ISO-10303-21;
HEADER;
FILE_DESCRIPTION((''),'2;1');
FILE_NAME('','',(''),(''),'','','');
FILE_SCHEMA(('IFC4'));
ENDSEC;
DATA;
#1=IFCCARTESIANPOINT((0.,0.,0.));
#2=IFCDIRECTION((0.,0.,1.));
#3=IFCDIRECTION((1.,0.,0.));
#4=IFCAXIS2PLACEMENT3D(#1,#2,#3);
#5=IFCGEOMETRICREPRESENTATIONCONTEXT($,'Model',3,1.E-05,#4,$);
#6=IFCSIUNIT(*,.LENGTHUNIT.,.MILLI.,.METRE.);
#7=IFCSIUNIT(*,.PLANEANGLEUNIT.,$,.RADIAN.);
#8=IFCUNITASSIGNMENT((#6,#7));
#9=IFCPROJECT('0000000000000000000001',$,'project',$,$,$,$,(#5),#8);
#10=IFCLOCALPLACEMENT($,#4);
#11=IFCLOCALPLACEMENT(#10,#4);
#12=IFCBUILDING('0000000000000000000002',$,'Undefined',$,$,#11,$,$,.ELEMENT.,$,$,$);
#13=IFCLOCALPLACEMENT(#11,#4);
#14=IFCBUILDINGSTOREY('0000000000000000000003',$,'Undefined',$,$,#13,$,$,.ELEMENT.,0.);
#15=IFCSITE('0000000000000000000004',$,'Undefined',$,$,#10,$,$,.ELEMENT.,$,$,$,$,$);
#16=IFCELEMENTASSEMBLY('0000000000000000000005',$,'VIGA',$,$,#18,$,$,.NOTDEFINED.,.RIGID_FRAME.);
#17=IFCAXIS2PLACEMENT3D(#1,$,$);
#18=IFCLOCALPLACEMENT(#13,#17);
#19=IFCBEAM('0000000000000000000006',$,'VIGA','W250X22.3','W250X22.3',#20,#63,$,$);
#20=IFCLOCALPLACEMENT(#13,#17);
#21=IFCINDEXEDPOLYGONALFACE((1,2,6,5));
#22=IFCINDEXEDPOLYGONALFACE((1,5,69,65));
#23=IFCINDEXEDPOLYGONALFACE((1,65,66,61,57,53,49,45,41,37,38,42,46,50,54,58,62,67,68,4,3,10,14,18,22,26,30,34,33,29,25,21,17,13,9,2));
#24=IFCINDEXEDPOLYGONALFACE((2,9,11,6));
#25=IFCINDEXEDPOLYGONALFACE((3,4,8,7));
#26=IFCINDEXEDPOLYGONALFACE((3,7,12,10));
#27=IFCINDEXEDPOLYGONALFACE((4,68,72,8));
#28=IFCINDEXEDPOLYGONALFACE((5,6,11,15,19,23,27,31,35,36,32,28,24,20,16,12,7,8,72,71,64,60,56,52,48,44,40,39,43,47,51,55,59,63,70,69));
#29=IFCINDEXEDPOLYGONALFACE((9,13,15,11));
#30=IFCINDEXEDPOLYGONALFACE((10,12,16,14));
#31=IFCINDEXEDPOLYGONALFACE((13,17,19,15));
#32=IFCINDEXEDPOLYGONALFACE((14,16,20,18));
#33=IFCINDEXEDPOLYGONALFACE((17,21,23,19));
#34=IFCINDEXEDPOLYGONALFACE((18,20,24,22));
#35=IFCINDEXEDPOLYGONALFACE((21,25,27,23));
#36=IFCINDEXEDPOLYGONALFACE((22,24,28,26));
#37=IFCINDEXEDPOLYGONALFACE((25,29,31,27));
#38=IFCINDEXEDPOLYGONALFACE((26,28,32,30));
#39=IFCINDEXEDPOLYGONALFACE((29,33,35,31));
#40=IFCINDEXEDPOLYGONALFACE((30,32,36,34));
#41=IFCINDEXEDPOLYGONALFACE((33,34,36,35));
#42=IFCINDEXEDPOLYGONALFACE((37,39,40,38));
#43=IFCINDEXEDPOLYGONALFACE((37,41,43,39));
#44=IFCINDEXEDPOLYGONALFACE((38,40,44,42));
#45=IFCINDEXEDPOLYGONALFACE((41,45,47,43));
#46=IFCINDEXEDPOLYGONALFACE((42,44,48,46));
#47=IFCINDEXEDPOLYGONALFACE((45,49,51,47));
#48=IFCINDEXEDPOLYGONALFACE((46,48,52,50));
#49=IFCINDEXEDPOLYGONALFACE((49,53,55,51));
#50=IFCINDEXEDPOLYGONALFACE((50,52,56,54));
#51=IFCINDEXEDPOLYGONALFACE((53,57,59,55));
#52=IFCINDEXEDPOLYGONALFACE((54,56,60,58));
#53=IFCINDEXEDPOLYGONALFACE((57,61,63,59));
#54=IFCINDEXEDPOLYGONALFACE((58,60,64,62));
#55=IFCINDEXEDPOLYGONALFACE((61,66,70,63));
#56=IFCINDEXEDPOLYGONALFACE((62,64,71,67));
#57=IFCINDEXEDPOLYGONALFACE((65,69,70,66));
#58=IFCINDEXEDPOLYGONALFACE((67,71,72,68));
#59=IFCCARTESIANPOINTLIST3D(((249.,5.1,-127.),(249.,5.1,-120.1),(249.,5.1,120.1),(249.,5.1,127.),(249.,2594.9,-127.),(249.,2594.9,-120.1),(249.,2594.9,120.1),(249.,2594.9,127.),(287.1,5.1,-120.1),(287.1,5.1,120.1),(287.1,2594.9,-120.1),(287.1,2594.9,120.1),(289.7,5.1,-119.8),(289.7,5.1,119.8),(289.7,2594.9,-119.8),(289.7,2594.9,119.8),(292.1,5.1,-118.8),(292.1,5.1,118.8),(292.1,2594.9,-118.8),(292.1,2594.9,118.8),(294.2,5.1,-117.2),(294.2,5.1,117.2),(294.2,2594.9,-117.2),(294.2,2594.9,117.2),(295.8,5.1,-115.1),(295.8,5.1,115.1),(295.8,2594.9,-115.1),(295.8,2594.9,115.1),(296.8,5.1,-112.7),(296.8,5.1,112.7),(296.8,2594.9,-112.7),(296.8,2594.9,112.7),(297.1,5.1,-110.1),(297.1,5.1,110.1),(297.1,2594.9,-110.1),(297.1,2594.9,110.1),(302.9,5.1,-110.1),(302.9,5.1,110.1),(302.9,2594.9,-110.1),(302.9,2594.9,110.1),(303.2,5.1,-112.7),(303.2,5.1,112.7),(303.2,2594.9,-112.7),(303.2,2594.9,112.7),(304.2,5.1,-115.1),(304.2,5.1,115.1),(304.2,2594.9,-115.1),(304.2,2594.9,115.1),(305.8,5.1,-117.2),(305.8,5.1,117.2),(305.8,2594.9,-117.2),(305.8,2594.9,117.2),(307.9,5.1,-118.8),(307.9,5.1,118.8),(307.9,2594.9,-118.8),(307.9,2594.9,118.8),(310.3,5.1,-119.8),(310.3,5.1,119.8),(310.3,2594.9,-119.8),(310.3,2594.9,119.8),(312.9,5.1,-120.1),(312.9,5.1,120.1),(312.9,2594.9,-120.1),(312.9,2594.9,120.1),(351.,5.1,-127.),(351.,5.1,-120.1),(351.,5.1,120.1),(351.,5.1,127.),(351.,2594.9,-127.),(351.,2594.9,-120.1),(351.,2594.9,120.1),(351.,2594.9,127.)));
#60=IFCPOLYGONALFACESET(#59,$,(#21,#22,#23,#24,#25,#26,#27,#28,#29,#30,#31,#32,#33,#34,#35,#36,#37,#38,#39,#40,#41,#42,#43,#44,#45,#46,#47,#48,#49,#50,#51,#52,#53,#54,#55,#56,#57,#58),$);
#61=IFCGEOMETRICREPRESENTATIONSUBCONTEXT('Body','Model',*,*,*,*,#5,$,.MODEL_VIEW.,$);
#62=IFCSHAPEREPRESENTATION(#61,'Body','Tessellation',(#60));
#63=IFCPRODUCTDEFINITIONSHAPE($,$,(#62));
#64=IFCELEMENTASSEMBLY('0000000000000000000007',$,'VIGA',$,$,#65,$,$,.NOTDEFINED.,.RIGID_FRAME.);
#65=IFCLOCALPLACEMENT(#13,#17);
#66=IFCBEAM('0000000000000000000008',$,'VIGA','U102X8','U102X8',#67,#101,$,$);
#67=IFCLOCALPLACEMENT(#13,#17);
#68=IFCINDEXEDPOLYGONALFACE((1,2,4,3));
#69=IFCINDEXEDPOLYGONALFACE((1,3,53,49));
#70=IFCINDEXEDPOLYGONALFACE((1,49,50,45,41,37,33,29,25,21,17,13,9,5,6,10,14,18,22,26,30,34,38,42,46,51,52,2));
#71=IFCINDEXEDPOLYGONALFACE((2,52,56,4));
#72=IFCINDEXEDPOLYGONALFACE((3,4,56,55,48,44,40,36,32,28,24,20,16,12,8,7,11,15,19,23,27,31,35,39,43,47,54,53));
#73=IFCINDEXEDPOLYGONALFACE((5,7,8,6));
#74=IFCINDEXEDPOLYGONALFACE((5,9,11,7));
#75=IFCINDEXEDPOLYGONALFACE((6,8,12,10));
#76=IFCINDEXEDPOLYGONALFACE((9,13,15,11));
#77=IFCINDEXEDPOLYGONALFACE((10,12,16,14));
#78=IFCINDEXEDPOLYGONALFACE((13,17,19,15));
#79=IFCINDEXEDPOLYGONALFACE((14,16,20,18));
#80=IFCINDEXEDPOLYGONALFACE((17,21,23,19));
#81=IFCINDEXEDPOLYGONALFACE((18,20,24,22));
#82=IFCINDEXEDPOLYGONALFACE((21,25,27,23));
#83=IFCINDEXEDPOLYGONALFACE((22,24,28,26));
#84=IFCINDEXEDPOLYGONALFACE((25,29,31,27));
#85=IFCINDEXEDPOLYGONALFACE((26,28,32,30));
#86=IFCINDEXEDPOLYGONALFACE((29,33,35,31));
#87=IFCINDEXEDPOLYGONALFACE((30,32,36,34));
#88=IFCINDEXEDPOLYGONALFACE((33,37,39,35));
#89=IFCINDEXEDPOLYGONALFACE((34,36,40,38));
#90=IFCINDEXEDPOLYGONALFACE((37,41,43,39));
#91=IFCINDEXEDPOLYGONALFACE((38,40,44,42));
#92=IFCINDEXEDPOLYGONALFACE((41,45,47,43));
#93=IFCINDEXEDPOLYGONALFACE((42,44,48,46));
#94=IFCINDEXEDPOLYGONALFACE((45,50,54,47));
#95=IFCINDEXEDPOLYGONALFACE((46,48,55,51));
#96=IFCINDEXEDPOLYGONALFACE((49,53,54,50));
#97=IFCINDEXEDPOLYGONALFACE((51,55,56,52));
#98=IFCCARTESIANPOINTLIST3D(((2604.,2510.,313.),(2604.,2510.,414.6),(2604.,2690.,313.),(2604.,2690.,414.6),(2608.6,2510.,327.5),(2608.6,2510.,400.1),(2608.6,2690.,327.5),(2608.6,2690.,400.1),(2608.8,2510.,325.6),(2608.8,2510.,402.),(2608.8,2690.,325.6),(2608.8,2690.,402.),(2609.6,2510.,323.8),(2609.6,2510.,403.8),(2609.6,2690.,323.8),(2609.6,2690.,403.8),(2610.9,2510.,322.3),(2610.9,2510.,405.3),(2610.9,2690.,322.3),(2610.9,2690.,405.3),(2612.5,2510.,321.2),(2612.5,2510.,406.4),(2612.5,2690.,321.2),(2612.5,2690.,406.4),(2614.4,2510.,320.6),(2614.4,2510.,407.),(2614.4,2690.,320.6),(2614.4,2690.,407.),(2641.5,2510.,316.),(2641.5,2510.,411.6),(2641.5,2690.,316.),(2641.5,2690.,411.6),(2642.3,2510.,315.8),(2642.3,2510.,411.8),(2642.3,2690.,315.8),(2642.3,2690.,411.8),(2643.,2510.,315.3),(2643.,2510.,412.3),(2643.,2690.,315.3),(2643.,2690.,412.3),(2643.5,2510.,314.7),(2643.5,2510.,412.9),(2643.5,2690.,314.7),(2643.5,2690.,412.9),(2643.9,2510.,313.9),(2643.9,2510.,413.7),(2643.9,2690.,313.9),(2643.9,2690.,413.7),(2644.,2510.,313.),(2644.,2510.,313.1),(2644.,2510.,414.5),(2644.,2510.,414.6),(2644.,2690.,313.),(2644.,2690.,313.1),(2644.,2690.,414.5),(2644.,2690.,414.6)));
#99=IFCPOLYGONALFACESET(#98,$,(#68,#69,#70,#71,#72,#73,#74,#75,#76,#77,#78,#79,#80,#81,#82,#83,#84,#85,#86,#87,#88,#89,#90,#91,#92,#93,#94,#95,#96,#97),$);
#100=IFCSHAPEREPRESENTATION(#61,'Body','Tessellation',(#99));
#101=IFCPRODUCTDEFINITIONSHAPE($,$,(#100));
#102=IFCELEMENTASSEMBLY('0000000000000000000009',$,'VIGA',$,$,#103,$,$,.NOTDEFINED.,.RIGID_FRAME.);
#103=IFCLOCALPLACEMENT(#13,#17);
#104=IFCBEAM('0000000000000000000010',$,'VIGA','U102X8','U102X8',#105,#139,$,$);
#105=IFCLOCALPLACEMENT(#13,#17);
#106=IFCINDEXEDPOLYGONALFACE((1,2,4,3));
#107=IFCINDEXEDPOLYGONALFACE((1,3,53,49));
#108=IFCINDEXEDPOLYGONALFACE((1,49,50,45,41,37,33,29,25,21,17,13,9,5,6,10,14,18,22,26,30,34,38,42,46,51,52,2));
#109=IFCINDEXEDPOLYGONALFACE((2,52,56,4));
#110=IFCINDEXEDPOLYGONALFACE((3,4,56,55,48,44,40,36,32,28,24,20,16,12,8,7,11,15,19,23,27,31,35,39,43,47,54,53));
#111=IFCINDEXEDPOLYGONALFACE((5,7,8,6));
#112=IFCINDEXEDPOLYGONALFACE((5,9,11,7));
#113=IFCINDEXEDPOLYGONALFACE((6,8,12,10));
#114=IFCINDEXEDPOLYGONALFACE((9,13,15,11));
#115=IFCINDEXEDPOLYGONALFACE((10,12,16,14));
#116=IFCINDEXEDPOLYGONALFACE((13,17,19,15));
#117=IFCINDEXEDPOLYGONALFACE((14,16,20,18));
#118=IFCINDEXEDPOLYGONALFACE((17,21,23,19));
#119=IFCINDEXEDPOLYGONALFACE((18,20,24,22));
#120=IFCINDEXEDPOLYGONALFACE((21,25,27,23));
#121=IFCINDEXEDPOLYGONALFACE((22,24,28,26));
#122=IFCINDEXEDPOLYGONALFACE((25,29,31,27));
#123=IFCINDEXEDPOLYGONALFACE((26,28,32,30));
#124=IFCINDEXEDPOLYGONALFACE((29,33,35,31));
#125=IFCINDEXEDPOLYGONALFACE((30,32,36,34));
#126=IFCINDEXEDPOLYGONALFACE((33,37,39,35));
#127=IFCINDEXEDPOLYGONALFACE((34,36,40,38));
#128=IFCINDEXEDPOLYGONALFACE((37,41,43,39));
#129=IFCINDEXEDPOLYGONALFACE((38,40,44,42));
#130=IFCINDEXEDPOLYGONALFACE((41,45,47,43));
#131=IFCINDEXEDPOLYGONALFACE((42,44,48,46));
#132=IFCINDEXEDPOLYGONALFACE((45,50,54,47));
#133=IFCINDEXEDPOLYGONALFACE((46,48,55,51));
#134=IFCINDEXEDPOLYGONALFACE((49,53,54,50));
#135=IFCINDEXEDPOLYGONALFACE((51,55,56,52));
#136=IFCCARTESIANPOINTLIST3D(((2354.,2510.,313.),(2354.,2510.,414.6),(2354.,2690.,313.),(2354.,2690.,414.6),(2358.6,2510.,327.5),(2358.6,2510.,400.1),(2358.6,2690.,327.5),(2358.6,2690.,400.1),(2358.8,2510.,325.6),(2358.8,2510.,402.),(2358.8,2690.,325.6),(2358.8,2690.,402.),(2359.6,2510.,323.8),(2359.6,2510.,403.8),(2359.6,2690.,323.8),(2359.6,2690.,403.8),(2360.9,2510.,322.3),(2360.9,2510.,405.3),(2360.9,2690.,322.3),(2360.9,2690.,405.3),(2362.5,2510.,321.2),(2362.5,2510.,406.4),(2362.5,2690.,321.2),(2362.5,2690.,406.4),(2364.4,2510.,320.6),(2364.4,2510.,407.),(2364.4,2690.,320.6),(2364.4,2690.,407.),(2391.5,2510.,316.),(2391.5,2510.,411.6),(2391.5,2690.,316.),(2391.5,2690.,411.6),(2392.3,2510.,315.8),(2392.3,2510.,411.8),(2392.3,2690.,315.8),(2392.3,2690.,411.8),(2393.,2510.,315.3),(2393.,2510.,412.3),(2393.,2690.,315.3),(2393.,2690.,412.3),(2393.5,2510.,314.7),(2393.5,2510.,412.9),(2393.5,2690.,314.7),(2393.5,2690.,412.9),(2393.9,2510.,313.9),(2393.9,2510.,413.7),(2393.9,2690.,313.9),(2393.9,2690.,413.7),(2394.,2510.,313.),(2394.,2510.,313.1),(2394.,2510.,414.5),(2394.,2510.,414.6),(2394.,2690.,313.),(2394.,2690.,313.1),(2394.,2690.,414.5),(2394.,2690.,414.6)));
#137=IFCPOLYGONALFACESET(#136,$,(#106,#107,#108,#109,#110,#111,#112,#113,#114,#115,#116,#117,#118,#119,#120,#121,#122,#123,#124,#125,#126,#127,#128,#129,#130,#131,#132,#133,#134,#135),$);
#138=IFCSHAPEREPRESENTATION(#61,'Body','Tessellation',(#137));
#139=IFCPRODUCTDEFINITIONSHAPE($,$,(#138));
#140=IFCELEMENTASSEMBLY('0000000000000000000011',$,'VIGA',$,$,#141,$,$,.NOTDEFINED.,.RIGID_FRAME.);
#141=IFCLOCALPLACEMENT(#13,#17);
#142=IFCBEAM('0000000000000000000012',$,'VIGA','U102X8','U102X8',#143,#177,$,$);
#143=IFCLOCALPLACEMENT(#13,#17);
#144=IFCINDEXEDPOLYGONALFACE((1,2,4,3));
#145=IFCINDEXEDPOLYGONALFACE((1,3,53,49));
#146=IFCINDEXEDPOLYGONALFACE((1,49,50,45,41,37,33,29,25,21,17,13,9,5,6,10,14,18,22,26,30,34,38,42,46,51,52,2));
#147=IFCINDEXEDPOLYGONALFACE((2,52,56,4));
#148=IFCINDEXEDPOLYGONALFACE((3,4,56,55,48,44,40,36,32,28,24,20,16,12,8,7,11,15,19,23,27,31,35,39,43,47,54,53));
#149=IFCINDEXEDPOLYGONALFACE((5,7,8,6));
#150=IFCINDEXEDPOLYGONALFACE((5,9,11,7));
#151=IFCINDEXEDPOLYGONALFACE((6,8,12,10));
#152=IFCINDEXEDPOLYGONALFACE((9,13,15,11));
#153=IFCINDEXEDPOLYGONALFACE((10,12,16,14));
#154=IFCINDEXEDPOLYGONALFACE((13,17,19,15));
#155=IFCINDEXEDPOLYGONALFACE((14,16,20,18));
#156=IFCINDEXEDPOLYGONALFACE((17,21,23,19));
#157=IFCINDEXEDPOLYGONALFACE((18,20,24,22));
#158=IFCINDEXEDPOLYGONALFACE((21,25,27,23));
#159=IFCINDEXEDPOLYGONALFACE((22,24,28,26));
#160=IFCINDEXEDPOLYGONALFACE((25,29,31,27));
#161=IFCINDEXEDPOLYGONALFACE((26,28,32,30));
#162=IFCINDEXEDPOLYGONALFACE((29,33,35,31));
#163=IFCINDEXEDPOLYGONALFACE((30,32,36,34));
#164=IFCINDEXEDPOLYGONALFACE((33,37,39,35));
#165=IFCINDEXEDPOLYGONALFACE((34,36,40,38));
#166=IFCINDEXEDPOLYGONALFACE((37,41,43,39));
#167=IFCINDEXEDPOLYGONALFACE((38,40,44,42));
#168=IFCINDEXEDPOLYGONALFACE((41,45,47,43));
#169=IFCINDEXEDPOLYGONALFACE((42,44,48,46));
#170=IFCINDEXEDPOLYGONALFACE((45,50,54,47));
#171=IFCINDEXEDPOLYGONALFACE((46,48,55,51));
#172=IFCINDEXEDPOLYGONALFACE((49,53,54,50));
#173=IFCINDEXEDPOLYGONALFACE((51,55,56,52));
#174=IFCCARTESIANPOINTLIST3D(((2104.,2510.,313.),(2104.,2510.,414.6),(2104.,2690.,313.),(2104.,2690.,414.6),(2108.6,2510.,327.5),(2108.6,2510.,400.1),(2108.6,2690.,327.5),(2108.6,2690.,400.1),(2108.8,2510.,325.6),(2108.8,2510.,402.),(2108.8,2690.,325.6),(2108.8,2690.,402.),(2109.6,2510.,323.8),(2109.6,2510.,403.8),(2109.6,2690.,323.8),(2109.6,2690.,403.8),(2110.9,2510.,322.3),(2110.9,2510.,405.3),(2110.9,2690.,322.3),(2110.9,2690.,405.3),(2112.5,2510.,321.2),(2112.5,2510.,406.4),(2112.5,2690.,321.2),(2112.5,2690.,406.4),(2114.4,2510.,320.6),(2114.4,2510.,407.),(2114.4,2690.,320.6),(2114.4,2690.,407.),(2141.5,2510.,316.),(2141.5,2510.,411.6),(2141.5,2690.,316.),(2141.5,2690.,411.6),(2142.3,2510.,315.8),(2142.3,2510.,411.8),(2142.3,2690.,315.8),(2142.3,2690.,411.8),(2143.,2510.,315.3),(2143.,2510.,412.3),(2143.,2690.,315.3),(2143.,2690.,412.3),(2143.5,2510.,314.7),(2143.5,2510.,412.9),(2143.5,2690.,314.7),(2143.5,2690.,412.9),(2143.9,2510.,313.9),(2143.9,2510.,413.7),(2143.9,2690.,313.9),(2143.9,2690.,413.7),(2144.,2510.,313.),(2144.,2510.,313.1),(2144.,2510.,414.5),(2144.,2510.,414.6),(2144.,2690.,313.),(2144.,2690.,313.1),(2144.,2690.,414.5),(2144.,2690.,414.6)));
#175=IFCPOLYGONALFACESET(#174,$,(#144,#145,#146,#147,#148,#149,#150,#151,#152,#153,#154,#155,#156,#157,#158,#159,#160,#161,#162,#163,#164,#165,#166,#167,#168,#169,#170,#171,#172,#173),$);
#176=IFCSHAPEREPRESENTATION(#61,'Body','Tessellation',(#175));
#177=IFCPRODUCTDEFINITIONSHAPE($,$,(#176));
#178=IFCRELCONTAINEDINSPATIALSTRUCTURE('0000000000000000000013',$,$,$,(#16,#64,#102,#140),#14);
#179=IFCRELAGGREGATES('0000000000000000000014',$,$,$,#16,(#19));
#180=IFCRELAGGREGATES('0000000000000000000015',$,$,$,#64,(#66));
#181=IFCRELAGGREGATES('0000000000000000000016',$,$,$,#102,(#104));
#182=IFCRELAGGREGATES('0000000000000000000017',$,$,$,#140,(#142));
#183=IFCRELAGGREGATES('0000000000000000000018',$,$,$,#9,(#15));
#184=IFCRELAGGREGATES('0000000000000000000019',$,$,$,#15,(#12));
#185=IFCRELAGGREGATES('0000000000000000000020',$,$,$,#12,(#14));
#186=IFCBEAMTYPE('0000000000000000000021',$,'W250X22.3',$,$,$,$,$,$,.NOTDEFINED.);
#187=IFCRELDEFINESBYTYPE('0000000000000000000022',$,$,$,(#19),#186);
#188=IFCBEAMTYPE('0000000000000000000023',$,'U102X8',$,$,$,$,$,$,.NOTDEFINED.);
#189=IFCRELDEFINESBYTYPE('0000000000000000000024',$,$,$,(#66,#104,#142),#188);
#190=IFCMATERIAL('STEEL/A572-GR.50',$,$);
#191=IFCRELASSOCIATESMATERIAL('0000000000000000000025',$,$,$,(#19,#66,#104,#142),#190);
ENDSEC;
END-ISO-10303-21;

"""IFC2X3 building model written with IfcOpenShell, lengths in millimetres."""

from ifc_helpers import new_model, si_unit, frame, origin_with_axes, origin_2d_with_axis, place, context, subcontext, project, spatial, i_section, u_section, extrude, material, type_object, element, aggregate, save


model = new_model("IFC2X3")

# Units and contexts
model_context = context("Model", 3, precision=1e-05, world=origin_with_axes())
body_context = subcontext(model_context, "Body", "Model", "MODEL_VIEW")
ifc_project = project(units=[si_unit("LENGTHUNIT", "METRE", prefix="MILLI"), si_unit("PLANEANGLEUNIT", "RADIAN")], contexts=[model_context])

# Site, building, storey
site_placement = place(None, origin_with_axes())
site = spatial("IfcSite", under=ifc_project, at=site_placement, Name="Undefined", CompositionType="ELEMENT")
building_placement = place(site_placement, origin_with_axes())
building = spatial("IfcBuilding", under=site, at=building_placement, Name="Undefined", CompositionType="ELEMENT")
storey_placement = place(building_placement, origin_with_axes())
storey = spatial("IfcBuildingStorey", under=building, at=storey_placement, Name="Undefined", CompositionType="ELEMENT", Elevation=0.0)

# Element assemblies, beams
assembly_1_placement = place(storey_placement, origin_with_axes())
assembly_1 = element("IfcElementAssembly", 1, at=assembly_1_placement, inside=storey, Name="VIGA", AssemblyPlace="NOTDEFINED", PredefinedType="RIGID_FRAME")
ifc_material_1 = material(Name="STEEL/A572-GR.50")
beam_type_1 = type_object("IfcBeamType", Name="W250X22.3", PredefinedType="NOTDEFINED")
beam_1_placement = place(assembly_1_placement, frame((300.0, 5.1, 0.0), z_axis=(0.0, 0.0, 1.0), x_axis=(0.0, 1.0, 0.0)))
beam_1 = element("IfcBeam", 2, at=beam_1_placement, type_object=beam_type_1, material=ifc_material_1, Name="VIGA", Description="W250X22.3", ObjectType="W250X22.3", context=body_context, shape_type="SweptSolid", body=[
    extrude(i_section(OverallWidth=102.0, OverallDepth=254.0, WebThickness=5.8, FlangeThickness=6.9, FilletRadius=10.0, at=origin_2d_with_axis()), frame((2589.8, 0.0, 0.0), z_axis=(-1.0, 0.0, 0.0), x_axis=(0.0, -1.0, 0.0)), (0.0, 0.0, 1.0), 2589.8),
])
aggregate(assembly_1, [beam_1])
assembly_2_placement = place(storey_placement, origin_with_axes())
assembly_2 = element("IfcElementAssembly", 3, at=assembly_2_placement, inside=storey, Name="VIGA", AssemblyPlace="NOTDEFINED", PredefinedType="RIGID_FRAME")
beam_type_2 = type_object("IfcBeamType", Name="U102X8", PredefinedType="NOTDEFINED")
beam_2_placement = place(assembly_2_placement, frame((2624.0, 2510.0, 363.8), z_axis=(0.0, 0.0, 1.0), x_axis=(0.0, 1.0, 0.0)))
beam_2 = element("IfcBeam", 4, at=beam_2_placement, type_object=beam_type_2, material=ifc_material_1, Name="VIGA", Description="U102X8", ObjectType="U102X8", context=body_context, shape_type="SweptSolid", body=[
    extrude(u_section(Depth=101.6, FlangeWidth=40.0, WebThickness=4.6, FlangeThickness=6.0, FilletRadius=7.0, EdgeRadius=3.0, FlangeSlope=0.16839, at=origin_2d_with_axis()), frame((180.0, 0.0, 0.0), z_axis=(-1.0, 0.0, 0.0), x_axis=(0.0, -1.0, 0.0)), (0.0, 0.0, 1.0), 180.0),
])
aggregate(assembly_2, [beam_2])
assembly_3_placement = place(storey_placement, origin_with_axes())
assembly_3 = element("IfcElementAssembly", 5, at=assembly_3_placement, inside=storey, Name="VIGA", AssemblyPlace="NOTDEFINED", PredefinedType="RIGID_FRAME")
beam_3_placement = place(assembly_3_placement, frame((2374.0, 2510.0, 363.8), z_axis=(0.0, 0.0, 1.0), x_axis=(0.0, 1.0, 0.0)))
beam_3 = element("IfcBeam", 6, at=beam_3_placement, type_object=beam_type_2, material=ifc_material_1, Name="VIGA", Description="U102X8", ObjectType="U102X8", context=body_context, shape_type="SweptSolid", body=[
    extrude(u_section(Depth=101.6, FlangeWidth=40.0, WebThickness=4.6, FlangeThickness=6.0, FilletRadius=7.0, EdgeRadius=3.0, FlangeSlope=0.16839, at=origin_2d_with_axis()), frame((180.0, 0.0, 0.0), z_axis=(-1.0, 0.0, 0.0), x_axis=(0.0, -1.0, 0.0)), (0.0, 0.0, 1.0), 180.0),
])
aggregate(assembly_3, [beam_3])
assembly_4_placement = place(storey_placement, origin_with_axes())
assembly_4 = element("IfcElementAssembly", 7, at=assembly_4_placement, inside=storey, Name="VIGA", AssemblyPlace="NOTDEFINED", PredefinedType="RIGID_FRAME")
beam_4_placement = place(assembly_4_placement, frame((2124.0, 2510.0, 363.8), z_axis=(0.0, 0.0, 1.0), x_axis=(0.0, 1.0, 0.0)))
beam_4 = element("IfcBeam", 8, at=beam_4_placement, type_object=beam_type_2, material=ifc_material_1, Name="VIGA", Description="U102X8", ObjectType="U102X8", context=body_context, shape_type="SweptSolid", body=[
    extrude(u_section(Depth=101.6, FlangeWidth=40.0, WebThickness=4.6, FlangeThickness=6.0, FilletRadius=7.0, EdgeRadius=3.0, FlangeSlope=0.16839, at=origin_2d_with_axis()), frame((180.0, 0.0, 0.0), z_axis=(-1.0, 0.0, 0.0), x_axis=(0.0, -1.0, 0.0)), (0.0, 0.0, 1.0), 180.0),
])
aggregate(assembly_4, [beam_4])

save(model, "model.ifc")
